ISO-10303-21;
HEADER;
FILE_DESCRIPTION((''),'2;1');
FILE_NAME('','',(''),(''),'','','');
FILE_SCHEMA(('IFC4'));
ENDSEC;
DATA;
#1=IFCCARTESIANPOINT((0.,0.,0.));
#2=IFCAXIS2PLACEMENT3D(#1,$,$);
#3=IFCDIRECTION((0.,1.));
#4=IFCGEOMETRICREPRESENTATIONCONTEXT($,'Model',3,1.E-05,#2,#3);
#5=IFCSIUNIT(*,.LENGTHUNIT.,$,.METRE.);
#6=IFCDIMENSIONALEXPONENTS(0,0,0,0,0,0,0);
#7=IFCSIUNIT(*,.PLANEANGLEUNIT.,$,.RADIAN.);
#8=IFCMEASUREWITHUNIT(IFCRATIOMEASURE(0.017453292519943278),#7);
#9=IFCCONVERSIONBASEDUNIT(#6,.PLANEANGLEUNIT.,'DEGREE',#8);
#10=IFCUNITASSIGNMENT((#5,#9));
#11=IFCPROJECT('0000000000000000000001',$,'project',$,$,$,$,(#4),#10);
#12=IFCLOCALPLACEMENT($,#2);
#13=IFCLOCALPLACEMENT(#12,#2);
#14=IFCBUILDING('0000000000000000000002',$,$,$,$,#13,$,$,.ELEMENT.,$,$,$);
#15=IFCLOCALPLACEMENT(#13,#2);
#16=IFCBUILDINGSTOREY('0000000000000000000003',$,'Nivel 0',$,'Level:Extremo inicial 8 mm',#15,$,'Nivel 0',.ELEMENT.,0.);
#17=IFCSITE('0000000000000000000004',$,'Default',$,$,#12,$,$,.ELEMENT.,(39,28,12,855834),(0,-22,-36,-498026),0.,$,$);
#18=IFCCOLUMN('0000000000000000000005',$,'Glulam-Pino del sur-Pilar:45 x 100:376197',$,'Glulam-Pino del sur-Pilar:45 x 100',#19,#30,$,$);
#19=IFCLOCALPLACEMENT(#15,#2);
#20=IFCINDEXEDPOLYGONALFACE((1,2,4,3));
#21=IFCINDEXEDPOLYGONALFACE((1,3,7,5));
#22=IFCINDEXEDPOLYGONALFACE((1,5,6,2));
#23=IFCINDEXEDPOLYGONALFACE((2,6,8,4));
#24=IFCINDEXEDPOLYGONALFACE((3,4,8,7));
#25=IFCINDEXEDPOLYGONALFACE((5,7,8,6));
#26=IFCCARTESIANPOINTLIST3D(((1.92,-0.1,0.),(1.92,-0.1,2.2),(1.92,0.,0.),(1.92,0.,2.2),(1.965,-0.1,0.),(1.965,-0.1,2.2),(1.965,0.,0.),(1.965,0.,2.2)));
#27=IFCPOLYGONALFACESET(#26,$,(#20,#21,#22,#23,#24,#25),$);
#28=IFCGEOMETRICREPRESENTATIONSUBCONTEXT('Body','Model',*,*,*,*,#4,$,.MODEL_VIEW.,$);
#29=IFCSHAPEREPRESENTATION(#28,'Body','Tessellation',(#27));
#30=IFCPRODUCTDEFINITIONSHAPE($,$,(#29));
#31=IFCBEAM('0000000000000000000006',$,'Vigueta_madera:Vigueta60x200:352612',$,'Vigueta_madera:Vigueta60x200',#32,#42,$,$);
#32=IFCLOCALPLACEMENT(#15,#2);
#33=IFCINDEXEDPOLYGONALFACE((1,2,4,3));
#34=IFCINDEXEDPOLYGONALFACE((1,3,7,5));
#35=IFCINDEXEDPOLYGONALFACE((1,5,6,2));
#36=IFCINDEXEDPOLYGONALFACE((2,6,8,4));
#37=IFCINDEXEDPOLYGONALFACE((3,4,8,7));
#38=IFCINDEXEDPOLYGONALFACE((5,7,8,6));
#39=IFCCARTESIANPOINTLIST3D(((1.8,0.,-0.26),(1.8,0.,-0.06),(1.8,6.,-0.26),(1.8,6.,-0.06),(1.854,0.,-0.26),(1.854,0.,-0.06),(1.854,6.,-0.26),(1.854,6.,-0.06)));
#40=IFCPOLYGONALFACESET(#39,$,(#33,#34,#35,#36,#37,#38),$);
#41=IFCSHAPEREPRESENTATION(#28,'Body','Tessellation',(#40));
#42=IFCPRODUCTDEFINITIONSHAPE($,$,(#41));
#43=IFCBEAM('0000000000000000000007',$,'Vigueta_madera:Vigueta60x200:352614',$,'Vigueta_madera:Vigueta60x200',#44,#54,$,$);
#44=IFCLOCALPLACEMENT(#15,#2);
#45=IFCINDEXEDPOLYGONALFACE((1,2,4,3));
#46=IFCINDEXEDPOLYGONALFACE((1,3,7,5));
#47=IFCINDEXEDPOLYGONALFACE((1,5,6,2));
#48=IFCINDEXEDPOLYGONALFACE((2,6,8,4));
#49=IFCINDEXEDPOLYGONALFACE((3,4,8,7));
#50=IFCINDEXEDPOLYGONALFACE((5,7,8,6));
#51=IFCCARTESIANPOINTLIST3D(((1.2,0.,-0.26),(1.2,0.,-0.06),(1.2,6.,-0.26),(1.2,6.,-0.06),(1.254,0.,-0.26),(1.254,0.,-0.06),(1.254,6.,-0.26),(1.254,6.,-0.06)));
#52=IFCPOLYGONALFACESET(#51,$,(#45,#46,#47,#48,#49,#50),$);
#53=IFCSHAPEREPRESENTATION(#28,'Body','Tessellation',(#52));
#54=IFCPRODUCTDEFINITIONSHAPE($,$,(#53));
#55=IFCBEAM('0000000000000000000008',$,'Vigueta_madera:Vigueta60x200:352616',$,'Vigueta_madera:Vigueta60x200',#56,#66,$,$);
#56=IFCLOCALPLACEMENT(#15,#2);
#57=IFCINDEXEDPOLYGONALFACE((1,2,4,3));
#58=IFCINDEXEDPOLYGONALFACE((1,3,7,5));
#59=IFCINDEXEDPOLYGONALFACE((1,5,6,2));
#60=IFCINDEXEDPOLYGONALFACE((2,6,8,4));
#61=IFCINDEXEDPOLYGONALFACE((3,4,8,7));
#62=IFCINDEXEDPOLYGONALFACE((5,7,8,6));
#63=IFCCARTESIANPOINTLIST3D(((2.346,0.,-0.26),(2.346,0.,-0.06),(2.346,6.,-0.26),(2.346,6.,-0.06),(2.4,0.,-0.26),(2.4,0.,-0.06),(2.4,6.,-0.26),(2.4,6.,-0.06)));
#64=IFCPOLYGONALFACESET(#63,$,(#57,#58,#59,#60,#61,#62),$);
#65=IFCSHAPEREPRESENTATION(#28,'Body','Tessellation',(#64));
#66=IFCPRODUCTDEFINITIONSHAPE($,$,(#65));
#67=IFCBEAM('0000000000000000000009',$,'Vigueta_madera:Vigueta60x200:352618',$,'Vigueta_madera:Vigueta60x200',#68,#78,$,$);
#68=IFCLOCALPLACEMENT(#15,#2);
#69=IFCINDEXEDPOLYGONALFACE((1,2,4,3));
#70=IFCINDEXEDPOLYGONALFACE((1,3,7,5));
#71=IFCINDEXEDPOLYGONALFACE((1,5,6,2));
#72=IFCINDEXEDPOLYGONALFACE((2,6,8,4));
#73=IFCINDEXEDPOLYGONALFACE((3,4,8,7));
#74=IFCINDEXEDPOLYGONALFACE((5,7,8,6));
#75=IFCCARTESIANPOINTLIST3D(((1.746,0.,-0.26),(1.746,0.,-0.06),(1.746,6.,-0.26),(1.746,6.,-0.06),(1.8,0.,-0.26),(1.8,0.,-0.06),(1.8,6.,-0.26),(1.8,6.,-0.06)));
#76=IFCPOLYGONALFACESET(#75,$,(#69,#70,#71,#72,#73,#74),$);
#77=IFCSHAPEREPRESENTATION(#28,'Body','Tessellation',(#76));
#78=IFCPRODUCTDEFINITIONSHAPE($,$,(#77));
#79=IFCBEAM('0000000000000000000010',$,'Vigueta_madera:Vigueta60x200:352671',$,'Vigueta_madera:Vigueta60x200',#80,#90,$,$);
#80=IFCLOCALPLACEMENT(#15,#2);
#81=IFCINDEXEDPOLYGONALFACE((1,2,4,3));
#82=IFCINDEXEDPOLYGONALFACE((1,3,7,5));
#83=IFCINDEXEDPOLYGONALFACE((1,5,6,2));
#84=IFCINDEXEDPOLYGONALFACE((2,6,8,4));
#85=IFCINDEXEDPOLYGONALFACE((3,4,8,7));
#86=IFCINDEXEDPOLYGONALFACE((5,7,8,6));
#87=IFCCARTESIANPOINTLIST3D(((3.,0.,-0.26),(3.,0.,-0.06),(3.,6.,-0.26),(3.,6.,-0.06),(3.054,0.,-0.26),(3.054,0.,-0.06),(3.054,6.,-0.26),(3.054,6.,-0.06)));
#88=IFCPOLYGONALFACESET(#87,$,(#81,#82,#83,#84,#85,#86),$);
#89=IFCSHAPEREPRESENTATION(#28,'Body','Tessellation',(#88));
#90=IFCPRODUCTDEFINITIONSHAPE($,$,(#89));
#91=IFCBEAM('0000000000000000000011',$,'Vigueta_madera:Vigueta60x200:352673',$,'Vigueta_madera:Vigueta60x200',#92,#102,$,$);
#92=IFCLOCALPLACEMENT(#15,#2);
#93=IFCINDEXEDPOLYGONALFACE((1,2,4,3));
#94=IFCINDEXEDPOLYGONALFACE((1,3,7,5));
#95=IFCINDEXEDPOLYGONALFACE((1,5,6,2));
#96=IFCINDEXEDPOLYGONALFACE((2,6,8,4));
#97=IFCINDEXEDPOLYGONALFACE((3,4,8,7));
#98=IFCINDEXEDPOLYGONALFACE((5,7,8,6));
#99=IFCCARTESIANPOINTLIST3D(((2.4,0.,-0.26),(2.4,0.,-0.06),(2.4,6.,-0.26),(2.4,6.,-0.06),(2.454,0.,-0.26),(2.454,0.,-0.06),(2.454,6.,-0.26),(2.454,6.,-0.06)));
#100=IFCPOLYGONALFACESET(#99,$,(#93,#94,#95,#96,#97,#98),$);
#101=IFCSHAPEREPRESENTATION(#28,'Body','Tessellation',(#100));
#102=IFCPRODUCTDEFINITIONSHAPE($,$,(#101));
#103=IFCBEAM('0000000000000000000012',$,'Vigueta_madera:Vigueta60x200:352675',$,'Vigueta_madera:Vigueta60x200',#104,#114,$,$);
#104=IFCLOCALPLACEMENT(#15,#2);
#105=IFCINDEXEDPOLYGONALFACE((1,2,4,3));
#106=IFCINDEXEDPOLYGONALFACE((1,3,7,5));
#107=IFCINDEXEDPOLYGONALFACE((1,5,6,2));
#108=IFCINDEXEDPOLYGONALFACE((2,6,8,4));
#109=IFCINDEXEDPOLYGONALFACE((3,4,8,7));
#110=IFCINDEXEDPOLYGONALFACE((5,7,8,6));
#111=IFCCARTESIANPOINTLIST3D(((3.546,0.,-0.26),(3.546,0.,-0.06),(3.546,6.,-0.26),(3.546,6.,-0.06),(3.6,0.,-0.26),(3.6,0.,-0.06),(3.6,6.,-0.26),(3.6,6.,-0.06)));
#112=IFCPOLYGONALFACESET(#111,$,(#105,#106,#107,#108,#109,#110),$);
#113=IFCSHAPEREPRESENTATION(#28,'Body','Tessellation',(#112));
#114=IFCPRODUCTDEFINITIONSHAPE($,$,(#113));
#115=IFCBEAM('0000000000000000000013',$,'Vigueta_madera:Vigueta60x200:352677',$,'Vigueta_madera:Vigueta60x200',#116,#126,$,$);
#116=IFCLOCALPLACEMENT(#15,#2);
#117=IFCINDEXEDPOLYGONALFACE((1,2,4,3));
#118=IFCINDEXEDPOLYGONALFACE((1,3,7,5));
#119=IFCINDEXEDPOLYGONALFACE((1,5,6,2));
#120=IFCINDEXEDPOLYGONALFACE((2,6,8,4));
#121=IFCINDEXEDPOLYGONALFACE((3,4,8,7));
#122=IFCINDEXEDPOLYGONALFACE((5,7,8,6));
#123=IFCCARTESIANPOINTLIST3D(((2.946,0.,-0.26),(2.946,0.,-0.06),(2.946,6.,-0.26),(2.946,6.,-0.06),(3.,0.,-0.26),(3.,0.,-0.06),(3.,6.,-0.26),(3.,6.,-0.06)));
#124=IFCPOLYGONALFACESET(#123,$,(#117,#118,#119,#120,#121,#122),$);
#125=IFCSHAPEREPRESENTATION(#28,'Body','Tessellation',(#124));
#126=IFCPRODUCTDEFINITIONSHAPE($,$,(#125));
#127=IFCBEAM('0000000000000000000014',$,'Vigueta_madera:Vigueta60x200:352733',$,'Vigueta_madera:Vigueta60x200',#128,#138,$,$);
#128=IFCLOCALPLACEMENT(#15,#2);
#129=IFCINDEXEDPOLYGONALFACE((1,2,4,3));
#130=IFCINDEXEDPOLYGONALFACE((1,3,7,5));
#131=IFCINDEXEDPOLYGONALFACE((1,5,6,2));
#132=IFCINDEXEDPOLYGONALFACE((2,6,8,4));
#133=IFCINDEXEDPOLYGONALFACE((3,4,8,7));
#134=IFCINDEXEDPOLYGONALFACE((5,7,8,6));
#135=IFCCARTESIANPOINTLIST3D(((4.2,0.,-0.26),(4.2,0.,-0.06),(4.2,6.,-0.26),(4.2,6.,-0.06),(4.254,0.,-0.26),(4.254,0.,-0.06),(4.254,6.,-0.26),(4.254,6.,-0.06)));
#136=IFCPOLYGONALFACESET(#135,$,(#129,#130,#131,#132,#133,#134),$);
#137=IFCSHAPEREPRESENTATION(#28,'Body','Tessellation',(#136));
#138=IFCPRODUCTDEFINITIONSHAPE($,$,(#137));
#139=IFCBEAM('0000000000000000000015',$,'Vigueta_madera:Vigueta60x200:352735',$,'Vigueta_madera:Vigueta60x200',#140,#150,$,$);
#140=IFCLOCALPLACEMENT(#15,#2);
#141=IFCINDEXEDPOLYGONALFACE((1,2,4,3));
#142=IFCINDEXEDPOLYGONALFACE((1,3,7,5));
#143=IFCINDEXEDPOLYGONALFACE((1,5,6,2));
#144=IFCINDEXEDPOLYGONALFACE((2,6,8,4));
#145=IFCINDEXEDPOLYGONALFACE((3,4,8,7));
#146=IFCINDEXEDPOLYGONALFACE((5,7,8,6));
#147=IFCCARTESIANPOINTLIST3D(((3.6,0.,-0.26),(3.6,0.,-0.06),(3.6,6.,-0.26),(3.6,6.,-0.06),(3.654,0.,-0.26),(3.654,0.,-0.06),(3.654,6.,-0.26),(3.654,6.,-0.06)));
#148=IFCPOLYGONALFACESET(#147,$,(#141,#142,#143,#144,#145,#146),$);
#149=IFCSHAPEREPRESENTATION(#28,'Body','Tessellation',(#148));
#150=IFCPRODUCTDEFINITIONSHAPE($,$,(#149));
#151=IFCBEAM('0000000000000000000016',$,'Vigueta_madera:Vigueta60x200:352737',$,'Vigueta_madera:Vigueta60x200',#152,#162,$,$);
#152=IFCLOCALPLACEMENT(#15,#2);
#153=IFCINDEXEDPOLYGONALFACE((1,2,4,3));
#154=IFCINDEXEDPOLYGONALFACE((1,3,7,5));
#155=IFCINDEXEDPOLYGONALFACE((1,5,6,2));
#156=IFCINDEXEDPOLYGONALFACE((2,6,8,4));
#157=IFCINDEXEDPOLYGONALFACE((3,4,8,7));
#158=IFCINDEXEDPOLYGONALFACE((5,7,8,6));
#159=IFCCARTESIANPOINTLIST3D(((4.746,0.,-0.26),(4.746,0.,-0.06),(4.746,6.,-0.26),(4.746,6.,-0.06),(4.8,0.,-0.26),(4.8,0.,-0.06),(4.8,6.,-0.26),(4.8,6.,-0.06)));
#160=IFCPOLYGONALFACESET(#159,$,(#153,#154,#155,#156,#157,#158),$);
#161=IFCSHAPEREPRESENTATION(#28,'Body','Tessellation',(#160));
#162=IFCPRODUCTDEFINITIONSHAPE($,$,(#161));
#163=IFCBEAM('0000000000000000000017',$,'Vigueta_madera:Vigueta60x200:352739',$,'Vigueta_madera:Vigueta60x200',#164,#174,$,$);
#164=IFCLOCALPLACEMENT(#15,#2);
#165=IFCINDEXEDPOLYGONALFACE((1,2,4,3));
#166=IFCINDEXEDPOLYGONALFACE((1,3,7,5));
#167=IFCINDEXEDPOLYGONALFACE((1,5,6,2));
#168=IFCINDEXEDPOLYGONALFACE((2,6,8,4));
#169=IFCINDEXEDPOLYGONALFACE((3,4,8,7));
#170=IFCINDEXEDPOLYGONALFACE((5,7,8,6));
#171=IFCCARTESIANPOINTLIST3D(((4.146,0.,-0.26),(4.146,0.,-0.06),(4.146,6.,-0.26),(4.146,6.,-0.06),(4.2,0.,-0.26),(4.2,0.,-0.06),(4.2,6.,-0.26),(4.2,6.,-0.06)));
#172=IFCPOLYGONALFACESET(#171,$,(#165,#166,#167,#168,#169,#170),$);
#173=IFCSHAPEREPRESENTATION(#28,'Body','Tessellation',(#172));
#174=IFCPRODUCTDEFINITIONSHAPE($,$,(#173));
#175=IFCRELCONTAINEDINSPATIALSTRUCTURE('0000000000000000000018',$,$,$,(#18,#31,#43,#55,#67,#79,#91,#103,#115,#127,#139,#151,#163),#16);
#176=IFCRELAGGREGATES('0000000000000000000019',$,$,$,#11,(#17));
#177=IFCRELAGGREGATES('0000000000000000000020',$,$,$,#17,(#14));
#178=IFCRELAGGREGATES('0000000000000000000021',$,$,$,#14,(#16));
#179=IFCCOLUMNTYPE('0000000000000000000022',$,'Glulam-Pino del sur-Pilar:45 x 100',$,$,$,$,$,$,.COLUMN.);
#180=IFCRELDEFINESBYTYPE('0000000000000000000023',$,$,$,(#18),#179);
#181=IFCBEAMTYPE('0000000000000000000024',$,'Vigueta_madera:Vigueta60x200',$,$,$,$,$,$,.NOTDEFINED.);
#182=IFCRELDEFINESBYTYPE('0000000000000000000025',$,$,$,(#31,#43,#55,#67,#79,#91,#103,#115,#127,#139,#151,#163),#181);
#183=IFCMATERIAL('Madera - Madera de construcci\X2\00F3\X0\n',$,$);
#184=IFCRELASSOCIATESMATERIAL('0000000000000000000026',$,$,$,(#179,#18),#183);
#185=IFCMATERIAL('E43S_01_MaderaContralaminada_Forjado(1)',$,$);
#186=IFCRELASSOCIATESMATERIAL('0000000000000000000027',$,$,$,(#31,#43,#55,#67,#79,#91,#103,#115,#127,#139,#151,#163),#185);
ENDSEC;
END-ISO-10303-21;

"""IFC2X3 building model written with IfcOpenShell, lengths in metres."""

from ifc_helpers import new_model, entity, si_unit, converted_unit, direction, frame, frame_2d, origin, origin_2d_with_axis, place, context, subcontext, project, spatial, rectangle, extrude, source, transform, mapped, material, type_object, type_shapes, element, save


model = new_model("IFC2X3")

# Units and contexts
model_context = context("Model", 3, precision=1e-05, world=origin(), true_north=direction((0.0, 1.0)))
body_context = subcontext(model_context, "Body", "Model", "MODEL_VIEW")
ifc_project = project(units=[si_unit("LENGTHUNIT", "METRE"), converted_unit("PLANEANGLEUNIT", "DEGREE", entity("IfcRatioMeasure", 0.017453292519943278), si_unit("PLANEANGLEUNIT", "RADIAN"), dimensions=[0, 0, 0, 0, 0, 0, 0])], contexts=[model_context])

# Site, building, storey
site_placement = place(None, origin())
site = spatial("IfcSite", under=ifc_project, at=site_placement, Name="Default", CompositionType="ELEMENT", RefLatitude=(39, 28, 12, 855834), RefLongitude=(0, -22, -36, -498026), RefElevation=0.0)
building_placement = place(site_placement, origin())
building = spatial("IfcBuilding", under=site, at=building_placement, CompositionType="ELEMENT")
storey_placement = place(building_placement, origin())
storey = spatial("IfcBuildingStorey", under=building, at=storey_placement, Name="Nivel 0", ObjectType="Level:Extremo inicial 8 mm", LongName="Nivel 0", CompositionType="ELEMENT", Elevation=0.0)

# Column
ifc_material_1 = material(Name="Madera - Madera de construcción")
column_type = type_object("IfcColumnType", Name="Glulam-Pino del sur-Pilar:45 x 100", PredefinedType="COLUMN", material=ifc_material_1)
shared_shape = source(origin(), body_context, "Body", "SweptSolid", [
    extrude(rectangle(XDim=0.1, YDim=0.045, at=origin_2d_with_axis()), frame((0.0, 0.0, 0.0), z_axis=(0.0, 0.0, 1.0), x_axis=(0.0, -1.0, 0.0)), (0.0, 0.0, 1.0), 2.2),
])
type_shapes(column_type, [shared_shape])
column_placement = place(storey_placement, frame((1.9425, -0.05, 0.0)))
element("IfcColumn", 1, at=column_placement, inside=storey, type_object=column_type, material=ifc_material_1, Name="Glulam-Pino del sur-Pilar:45 x 100:376197", ObjectType="Glulam-Pino del sur-Pilar:45 x 100", context=body_context, shape_type="MappedRepresentation", body=[
    mapped(shared_shape, transform((0.0, 0.0, 0.0), scale=1.0)),
])

# Beams
ifc_material_2 = material(Name="E43S_01_MaderaContralaminada_Forjado(1)")
beam_type = type_object("IfcBeamType", Name="Vigueta_madera:Vigueta60x200", PredefinedType="NOTDEFINED")
beam_1_placement = place(storey_placement, frame((1.827, 0.0, -0.06), z_axis=(0.0, 0.0, 1.0), x_axis=(0.0, 1.0, 0.0)))
element("IfcBeam", 2, at=beam_1_placement, inside=storey, type_object=beam_type, material=ifc_material_2, Name="Vigueta_madera:Vigueta60x200:352612", ObjectType="Vigueta_madera:Vigueta60x200", context=body_context, shape_type="SweptSolid", body=[
    extrude(rectangle(XDim=0.2, YDim=0.054, at=frame_2d((0.0, 0.0), x_axis=(1.0, 0.0))), frame((0.0, 0.0, -0.1), z_axis=(1.0, 0.0, 0.0), x_axis=(0.0, 0.0, -1.0)), (0.0, 0.0, 1.0), 6.0),
])
beam_2_placement = place(storey_placement, frame((1.227, 0.0, -0.06), z_axis=(0.0, 0.0, 1.0), x_axis=(0.0, 1.0, 0.0)))
element("IfcBeam", 3, at=beam_2_placement, inside=storey, type_object=beam_type, material=ifc_material_2, Name="Vigueta_madera:Vigueta60x200:352614", ObjectType="Vigueta_madera:Vigueta60x200", context=body_context, shape_type="SweptSolid", body=[
    extrude(rectangle(XDim=0.2, YDim=0.054, at=origin_2d_with_axis()), frame((0.0, 0.0, -0.1), z_axis=(1.0, 0.0, 0.0), x_axis=(0.0, 0.0, -1.0)), (0.0, 0.0, 1.0), 6.0),
])
beam_3_placement = place(storey_placement, frame((2.373, 0.0, -0.06), z_axis=(0.0, 0.0, 1.0), x_axis=(0.0, 1.0, 0.0)))
element("IfcBeam", 4, at=beam_3_placement, inside=storey, type_object=beam_type, material=ifc_material_2, Name="Vigueta_madera:Vigueta60x200:352616", ObjectType="Vigueta_madera:Vigueta60x200", context=body_context, shape_type="SweptSolid", body=[
    extrude(rectangle(XDim=0.2, YDim=0.054, at=origin_2d_with_axis()), frame((0.0, 0.0, -0.1), z_axis=(1.0, 0.0, 0.0), x_axis=(0.0, 0.0, -1.0)), (0.0, 0.0, 1.0), 6.0),
])
beam_4_placement = place(storey_placement, frame((1.773, 0.0, -0.06), z_axis=(0.0, 0.0, 1.0), x_axis=(0.0, 1.0, 0.0)))
element("IfcBeam", 5, at=beam_4_placement, inside=storey, type_object=beam_type, material=ifc_material_2, Name="Vigueta_madera:Vigueta60x200:352618", ObjectType="Vigueta_madera:Vigueta60x200", context=body_context, shape_type="SweptSolid", body=[
    extrude(rectangle(XDim=0.2, YDim=0.054, at=origin_2d_with_axis()), frame((0.0, 0.0, -0.1), z_axis=(1.0, 0.0, 0.0), x_axis=(0.0, 0.0, -1.0)), (0.0, 0.0, 1.0), 6.0),
])
beam_5_placement = place(storey_placement, frame((3.027, 0.0, -0.06), z_axis=(0.0, 0.0, 1.0), x_axis=(0.0, 1.0, 0.0)))
element("IfcBeam", 6, at=beam_5_placement, inside=storey, type_object=beam_type, material=ifc_material_2, Name="Vigueta_madera:Vigueta60x200:352671", ObjectType="Vigueta_madera:Vigueta60x200", context=body_context, shape_type="SweptSolid", body=[
    extrude(rectangle(XDim=0.2, YDim=0.054, at=frame_2d((0.0, 0.0), x_axis=(1.0, 0.0))), frame((0.0, 0.0, -0.1), z_axis=(1.0, 0.0, 0.0), x_axis=(0.0, 0.0, -1.0)), (0.0, 0.0, 1.0), 6.0),
])
beam_6_placement = place(storey_placement, frame((2.427, 0.0, -0.06), z_axis=(0.0, 0.0, 1.0), x_axis=(0.0, 1.0, 0.0)))
element("IfcBeam", 7, at=beam_6_placement, inside=storey, type_object=beam_type, material=ifc_material_2, Name="Vigueta_madera:Vigueta60x200:352673", ObjectType="Vigueta_madera:Vigueta60x200", context=body_context, shape_type="SweptSolid", body=[
    extrude(rectangle(XDim=0.2, YDim=0.054, at=frame_2d((0.0, 0.0), x_axis=(1.0, 0.0))), frame((0.0, 0.0, -0.1), z_axis=(1.0, 0.0, 0.0), x_axis=(0.0, 0.0, -1.0)), (0.0, 0.0, 1.0), 6.0),
])
beam_7_placement = place(storey_placement, frame((3.573, 0.0, -0.06), z_axis=(0.0, 0.0, 1.0), x_axis=(0.0, 1.0, 0.0)))
element("IfcBeam", 8, at=beam_7_placement, inside=storey, type_object=beam_type, material=ifc_material_2, Name="Vigueta_madera:Vigueta60x200:352675", ObjectType="Vigueta_madera:Vigueta60x200", context=body_context, shape_type="SweptSolid", body=[
    extrude(rectangle(XDim=0.2, YDim=0.054, at=origin_2d_with_axis()), frame((0.0, 0.0, -0.1), z_axis=(1.0, 0.0, 0.0), x_axis=(0.0, 0.0, -1.0)), (0.0, 0.0, 1.0), 6.0),
])
beam_8_placement = place(storey_placement, frame((2.973, 0.0, -0.06), z_axis=(0.0, 0.0, 1.0), x_axis=(0.0, 1.0, 0.0)))
element("IfcBeam", 9, at=beam_8_placement, inside=storey, type_object=beam_type, material=ifc_material_2, Name="Vigueta_madera:Vigueta60x200:352677", ObjectType="Vigueta_madera:Vigueta60x200", context=body_context, shape_type="SweptSolid", body=[
    extrude(rectangle(XDim=0.2, YDim=0.054, at=frame_2d((0.0, 0.0), x_axis=(1.0, 0.0))), frame((0.0, 0.0, -0.1), z_axis=(1.0, 0.0, 0.0), x_axis=(0.0, 0.0, -1.0)), (0.0, 0.0, 1.0), 6.0),
])
beam_9_placement = place(storey_placement, frame((4.227, 0.0, -0.06), z_axis=(0.0, 0.0, 1.0), x_axis=(0.0, 1.0, 0.0)))
element("IfcBeam", 10, at=beam_9_placement, inside=storey, type_object=beam_type, material=ifc_material_2, Name="Vigueta_madera:Vigueta60x200:352733", ObjectType="Vigueta_madera:Vigueta60x200", context=body_context, shape_type="SweptSolid", body=[
    extrude(rectangle(XDim=0.2, YDim=0.054, at=frame_2d((0.0, 0.0), x_axis=(1.0, 0.0))), frame((0.0, 0.0, -0.1), z_axis=(1.0, 0.0, 0.0), x_axis=(0.0, 0.0, -1.0)), (0.0, 0.0, 1.0), 6.0),
])
beam_10_placement = place(storey_placement, frame((3.627, 0.0, -0.06), z_axis=(0.0, 0.0, 1.0), x_axis=(0.0, 1.0, 0.0)))
element("IfcBeam", 11, at=beam_10_placement, inside=storey, type_object=beam_type, material=ifc_material_2, Name="Vigueta_madera:Vigueta60x200:352735", ObjectType="Vigueta_madera:Vigueta60x200", context=body_context, shape_type="SweptSolid", body=[
    extrude(rectangle(XDim=0.2, YDim=0.054, at=frame_2d((0.0, 0.0), x_axis=(1.0, 0.0))), frame((0.0, 0.0, -0.1), z_axis=(1.0, 0.0, 0.0), x_axis=(0.0, 0.0, -1.0)), (0.0, 0.0, 1.0), 6.0),
])
beam_11_placement = place(storey_placement, frame((4.773, 0.0, -0.06), z_axis=(0.0, 0.0, 1.0), x_axis=(0.0, 1.0, 0.0)))
element("IfcBeam", 12, at=beam_11_placement, inside=storey, type_object=beam_type, material=ifc_material_2, Name="Vigueta_madera:Vigueta60x200:352737", ObjectType="Vigueta_madera:Vigueta60x200", context=body_context, shape_type="SweptSolid", body=[
    extrude(rectangle(XDim=0.2, YDim=0.054, at=origin_2d_with_axis()), frame((0.0, 0.0, -0.1), z_axis=(1.0, 0.0, 0.0), x_axis=(0.0, 0.0, -1.0)), (0.0, 0.0, 1.0), 6.0),
])
beam_12_placement = place(storey_placement, frame((4.173, 0.0, -0.06), z_axis=(0.0, 0.0, 1.0), x_axis=(0.0, 1.0, 0.0)))
element("IfcBeam", 13, at=beam_12_placement, inside=storey, type_object=beam_type, material=ifc_material_2, Name="Vigueta_madera:Vigueta60x200:352739", ObjectType="Vigueta_madera:Vigueta60x200", context=body_context, shape_type="SweptSolid", body=[
    extrude(rectangle(XDim=0.2, YDim=0.054, at=frame_2d((0.0, 0.0), x_axis=(1.0, 0.0))), frame((0.0, 0.0, -0.1), z_axis=(1.0, 0.0, 0.0), x_axis=(0.0, 0.0, -1.0)), (0.0, 0.0, 1.0), 6.0),
])

save(model, "model.ifc")
